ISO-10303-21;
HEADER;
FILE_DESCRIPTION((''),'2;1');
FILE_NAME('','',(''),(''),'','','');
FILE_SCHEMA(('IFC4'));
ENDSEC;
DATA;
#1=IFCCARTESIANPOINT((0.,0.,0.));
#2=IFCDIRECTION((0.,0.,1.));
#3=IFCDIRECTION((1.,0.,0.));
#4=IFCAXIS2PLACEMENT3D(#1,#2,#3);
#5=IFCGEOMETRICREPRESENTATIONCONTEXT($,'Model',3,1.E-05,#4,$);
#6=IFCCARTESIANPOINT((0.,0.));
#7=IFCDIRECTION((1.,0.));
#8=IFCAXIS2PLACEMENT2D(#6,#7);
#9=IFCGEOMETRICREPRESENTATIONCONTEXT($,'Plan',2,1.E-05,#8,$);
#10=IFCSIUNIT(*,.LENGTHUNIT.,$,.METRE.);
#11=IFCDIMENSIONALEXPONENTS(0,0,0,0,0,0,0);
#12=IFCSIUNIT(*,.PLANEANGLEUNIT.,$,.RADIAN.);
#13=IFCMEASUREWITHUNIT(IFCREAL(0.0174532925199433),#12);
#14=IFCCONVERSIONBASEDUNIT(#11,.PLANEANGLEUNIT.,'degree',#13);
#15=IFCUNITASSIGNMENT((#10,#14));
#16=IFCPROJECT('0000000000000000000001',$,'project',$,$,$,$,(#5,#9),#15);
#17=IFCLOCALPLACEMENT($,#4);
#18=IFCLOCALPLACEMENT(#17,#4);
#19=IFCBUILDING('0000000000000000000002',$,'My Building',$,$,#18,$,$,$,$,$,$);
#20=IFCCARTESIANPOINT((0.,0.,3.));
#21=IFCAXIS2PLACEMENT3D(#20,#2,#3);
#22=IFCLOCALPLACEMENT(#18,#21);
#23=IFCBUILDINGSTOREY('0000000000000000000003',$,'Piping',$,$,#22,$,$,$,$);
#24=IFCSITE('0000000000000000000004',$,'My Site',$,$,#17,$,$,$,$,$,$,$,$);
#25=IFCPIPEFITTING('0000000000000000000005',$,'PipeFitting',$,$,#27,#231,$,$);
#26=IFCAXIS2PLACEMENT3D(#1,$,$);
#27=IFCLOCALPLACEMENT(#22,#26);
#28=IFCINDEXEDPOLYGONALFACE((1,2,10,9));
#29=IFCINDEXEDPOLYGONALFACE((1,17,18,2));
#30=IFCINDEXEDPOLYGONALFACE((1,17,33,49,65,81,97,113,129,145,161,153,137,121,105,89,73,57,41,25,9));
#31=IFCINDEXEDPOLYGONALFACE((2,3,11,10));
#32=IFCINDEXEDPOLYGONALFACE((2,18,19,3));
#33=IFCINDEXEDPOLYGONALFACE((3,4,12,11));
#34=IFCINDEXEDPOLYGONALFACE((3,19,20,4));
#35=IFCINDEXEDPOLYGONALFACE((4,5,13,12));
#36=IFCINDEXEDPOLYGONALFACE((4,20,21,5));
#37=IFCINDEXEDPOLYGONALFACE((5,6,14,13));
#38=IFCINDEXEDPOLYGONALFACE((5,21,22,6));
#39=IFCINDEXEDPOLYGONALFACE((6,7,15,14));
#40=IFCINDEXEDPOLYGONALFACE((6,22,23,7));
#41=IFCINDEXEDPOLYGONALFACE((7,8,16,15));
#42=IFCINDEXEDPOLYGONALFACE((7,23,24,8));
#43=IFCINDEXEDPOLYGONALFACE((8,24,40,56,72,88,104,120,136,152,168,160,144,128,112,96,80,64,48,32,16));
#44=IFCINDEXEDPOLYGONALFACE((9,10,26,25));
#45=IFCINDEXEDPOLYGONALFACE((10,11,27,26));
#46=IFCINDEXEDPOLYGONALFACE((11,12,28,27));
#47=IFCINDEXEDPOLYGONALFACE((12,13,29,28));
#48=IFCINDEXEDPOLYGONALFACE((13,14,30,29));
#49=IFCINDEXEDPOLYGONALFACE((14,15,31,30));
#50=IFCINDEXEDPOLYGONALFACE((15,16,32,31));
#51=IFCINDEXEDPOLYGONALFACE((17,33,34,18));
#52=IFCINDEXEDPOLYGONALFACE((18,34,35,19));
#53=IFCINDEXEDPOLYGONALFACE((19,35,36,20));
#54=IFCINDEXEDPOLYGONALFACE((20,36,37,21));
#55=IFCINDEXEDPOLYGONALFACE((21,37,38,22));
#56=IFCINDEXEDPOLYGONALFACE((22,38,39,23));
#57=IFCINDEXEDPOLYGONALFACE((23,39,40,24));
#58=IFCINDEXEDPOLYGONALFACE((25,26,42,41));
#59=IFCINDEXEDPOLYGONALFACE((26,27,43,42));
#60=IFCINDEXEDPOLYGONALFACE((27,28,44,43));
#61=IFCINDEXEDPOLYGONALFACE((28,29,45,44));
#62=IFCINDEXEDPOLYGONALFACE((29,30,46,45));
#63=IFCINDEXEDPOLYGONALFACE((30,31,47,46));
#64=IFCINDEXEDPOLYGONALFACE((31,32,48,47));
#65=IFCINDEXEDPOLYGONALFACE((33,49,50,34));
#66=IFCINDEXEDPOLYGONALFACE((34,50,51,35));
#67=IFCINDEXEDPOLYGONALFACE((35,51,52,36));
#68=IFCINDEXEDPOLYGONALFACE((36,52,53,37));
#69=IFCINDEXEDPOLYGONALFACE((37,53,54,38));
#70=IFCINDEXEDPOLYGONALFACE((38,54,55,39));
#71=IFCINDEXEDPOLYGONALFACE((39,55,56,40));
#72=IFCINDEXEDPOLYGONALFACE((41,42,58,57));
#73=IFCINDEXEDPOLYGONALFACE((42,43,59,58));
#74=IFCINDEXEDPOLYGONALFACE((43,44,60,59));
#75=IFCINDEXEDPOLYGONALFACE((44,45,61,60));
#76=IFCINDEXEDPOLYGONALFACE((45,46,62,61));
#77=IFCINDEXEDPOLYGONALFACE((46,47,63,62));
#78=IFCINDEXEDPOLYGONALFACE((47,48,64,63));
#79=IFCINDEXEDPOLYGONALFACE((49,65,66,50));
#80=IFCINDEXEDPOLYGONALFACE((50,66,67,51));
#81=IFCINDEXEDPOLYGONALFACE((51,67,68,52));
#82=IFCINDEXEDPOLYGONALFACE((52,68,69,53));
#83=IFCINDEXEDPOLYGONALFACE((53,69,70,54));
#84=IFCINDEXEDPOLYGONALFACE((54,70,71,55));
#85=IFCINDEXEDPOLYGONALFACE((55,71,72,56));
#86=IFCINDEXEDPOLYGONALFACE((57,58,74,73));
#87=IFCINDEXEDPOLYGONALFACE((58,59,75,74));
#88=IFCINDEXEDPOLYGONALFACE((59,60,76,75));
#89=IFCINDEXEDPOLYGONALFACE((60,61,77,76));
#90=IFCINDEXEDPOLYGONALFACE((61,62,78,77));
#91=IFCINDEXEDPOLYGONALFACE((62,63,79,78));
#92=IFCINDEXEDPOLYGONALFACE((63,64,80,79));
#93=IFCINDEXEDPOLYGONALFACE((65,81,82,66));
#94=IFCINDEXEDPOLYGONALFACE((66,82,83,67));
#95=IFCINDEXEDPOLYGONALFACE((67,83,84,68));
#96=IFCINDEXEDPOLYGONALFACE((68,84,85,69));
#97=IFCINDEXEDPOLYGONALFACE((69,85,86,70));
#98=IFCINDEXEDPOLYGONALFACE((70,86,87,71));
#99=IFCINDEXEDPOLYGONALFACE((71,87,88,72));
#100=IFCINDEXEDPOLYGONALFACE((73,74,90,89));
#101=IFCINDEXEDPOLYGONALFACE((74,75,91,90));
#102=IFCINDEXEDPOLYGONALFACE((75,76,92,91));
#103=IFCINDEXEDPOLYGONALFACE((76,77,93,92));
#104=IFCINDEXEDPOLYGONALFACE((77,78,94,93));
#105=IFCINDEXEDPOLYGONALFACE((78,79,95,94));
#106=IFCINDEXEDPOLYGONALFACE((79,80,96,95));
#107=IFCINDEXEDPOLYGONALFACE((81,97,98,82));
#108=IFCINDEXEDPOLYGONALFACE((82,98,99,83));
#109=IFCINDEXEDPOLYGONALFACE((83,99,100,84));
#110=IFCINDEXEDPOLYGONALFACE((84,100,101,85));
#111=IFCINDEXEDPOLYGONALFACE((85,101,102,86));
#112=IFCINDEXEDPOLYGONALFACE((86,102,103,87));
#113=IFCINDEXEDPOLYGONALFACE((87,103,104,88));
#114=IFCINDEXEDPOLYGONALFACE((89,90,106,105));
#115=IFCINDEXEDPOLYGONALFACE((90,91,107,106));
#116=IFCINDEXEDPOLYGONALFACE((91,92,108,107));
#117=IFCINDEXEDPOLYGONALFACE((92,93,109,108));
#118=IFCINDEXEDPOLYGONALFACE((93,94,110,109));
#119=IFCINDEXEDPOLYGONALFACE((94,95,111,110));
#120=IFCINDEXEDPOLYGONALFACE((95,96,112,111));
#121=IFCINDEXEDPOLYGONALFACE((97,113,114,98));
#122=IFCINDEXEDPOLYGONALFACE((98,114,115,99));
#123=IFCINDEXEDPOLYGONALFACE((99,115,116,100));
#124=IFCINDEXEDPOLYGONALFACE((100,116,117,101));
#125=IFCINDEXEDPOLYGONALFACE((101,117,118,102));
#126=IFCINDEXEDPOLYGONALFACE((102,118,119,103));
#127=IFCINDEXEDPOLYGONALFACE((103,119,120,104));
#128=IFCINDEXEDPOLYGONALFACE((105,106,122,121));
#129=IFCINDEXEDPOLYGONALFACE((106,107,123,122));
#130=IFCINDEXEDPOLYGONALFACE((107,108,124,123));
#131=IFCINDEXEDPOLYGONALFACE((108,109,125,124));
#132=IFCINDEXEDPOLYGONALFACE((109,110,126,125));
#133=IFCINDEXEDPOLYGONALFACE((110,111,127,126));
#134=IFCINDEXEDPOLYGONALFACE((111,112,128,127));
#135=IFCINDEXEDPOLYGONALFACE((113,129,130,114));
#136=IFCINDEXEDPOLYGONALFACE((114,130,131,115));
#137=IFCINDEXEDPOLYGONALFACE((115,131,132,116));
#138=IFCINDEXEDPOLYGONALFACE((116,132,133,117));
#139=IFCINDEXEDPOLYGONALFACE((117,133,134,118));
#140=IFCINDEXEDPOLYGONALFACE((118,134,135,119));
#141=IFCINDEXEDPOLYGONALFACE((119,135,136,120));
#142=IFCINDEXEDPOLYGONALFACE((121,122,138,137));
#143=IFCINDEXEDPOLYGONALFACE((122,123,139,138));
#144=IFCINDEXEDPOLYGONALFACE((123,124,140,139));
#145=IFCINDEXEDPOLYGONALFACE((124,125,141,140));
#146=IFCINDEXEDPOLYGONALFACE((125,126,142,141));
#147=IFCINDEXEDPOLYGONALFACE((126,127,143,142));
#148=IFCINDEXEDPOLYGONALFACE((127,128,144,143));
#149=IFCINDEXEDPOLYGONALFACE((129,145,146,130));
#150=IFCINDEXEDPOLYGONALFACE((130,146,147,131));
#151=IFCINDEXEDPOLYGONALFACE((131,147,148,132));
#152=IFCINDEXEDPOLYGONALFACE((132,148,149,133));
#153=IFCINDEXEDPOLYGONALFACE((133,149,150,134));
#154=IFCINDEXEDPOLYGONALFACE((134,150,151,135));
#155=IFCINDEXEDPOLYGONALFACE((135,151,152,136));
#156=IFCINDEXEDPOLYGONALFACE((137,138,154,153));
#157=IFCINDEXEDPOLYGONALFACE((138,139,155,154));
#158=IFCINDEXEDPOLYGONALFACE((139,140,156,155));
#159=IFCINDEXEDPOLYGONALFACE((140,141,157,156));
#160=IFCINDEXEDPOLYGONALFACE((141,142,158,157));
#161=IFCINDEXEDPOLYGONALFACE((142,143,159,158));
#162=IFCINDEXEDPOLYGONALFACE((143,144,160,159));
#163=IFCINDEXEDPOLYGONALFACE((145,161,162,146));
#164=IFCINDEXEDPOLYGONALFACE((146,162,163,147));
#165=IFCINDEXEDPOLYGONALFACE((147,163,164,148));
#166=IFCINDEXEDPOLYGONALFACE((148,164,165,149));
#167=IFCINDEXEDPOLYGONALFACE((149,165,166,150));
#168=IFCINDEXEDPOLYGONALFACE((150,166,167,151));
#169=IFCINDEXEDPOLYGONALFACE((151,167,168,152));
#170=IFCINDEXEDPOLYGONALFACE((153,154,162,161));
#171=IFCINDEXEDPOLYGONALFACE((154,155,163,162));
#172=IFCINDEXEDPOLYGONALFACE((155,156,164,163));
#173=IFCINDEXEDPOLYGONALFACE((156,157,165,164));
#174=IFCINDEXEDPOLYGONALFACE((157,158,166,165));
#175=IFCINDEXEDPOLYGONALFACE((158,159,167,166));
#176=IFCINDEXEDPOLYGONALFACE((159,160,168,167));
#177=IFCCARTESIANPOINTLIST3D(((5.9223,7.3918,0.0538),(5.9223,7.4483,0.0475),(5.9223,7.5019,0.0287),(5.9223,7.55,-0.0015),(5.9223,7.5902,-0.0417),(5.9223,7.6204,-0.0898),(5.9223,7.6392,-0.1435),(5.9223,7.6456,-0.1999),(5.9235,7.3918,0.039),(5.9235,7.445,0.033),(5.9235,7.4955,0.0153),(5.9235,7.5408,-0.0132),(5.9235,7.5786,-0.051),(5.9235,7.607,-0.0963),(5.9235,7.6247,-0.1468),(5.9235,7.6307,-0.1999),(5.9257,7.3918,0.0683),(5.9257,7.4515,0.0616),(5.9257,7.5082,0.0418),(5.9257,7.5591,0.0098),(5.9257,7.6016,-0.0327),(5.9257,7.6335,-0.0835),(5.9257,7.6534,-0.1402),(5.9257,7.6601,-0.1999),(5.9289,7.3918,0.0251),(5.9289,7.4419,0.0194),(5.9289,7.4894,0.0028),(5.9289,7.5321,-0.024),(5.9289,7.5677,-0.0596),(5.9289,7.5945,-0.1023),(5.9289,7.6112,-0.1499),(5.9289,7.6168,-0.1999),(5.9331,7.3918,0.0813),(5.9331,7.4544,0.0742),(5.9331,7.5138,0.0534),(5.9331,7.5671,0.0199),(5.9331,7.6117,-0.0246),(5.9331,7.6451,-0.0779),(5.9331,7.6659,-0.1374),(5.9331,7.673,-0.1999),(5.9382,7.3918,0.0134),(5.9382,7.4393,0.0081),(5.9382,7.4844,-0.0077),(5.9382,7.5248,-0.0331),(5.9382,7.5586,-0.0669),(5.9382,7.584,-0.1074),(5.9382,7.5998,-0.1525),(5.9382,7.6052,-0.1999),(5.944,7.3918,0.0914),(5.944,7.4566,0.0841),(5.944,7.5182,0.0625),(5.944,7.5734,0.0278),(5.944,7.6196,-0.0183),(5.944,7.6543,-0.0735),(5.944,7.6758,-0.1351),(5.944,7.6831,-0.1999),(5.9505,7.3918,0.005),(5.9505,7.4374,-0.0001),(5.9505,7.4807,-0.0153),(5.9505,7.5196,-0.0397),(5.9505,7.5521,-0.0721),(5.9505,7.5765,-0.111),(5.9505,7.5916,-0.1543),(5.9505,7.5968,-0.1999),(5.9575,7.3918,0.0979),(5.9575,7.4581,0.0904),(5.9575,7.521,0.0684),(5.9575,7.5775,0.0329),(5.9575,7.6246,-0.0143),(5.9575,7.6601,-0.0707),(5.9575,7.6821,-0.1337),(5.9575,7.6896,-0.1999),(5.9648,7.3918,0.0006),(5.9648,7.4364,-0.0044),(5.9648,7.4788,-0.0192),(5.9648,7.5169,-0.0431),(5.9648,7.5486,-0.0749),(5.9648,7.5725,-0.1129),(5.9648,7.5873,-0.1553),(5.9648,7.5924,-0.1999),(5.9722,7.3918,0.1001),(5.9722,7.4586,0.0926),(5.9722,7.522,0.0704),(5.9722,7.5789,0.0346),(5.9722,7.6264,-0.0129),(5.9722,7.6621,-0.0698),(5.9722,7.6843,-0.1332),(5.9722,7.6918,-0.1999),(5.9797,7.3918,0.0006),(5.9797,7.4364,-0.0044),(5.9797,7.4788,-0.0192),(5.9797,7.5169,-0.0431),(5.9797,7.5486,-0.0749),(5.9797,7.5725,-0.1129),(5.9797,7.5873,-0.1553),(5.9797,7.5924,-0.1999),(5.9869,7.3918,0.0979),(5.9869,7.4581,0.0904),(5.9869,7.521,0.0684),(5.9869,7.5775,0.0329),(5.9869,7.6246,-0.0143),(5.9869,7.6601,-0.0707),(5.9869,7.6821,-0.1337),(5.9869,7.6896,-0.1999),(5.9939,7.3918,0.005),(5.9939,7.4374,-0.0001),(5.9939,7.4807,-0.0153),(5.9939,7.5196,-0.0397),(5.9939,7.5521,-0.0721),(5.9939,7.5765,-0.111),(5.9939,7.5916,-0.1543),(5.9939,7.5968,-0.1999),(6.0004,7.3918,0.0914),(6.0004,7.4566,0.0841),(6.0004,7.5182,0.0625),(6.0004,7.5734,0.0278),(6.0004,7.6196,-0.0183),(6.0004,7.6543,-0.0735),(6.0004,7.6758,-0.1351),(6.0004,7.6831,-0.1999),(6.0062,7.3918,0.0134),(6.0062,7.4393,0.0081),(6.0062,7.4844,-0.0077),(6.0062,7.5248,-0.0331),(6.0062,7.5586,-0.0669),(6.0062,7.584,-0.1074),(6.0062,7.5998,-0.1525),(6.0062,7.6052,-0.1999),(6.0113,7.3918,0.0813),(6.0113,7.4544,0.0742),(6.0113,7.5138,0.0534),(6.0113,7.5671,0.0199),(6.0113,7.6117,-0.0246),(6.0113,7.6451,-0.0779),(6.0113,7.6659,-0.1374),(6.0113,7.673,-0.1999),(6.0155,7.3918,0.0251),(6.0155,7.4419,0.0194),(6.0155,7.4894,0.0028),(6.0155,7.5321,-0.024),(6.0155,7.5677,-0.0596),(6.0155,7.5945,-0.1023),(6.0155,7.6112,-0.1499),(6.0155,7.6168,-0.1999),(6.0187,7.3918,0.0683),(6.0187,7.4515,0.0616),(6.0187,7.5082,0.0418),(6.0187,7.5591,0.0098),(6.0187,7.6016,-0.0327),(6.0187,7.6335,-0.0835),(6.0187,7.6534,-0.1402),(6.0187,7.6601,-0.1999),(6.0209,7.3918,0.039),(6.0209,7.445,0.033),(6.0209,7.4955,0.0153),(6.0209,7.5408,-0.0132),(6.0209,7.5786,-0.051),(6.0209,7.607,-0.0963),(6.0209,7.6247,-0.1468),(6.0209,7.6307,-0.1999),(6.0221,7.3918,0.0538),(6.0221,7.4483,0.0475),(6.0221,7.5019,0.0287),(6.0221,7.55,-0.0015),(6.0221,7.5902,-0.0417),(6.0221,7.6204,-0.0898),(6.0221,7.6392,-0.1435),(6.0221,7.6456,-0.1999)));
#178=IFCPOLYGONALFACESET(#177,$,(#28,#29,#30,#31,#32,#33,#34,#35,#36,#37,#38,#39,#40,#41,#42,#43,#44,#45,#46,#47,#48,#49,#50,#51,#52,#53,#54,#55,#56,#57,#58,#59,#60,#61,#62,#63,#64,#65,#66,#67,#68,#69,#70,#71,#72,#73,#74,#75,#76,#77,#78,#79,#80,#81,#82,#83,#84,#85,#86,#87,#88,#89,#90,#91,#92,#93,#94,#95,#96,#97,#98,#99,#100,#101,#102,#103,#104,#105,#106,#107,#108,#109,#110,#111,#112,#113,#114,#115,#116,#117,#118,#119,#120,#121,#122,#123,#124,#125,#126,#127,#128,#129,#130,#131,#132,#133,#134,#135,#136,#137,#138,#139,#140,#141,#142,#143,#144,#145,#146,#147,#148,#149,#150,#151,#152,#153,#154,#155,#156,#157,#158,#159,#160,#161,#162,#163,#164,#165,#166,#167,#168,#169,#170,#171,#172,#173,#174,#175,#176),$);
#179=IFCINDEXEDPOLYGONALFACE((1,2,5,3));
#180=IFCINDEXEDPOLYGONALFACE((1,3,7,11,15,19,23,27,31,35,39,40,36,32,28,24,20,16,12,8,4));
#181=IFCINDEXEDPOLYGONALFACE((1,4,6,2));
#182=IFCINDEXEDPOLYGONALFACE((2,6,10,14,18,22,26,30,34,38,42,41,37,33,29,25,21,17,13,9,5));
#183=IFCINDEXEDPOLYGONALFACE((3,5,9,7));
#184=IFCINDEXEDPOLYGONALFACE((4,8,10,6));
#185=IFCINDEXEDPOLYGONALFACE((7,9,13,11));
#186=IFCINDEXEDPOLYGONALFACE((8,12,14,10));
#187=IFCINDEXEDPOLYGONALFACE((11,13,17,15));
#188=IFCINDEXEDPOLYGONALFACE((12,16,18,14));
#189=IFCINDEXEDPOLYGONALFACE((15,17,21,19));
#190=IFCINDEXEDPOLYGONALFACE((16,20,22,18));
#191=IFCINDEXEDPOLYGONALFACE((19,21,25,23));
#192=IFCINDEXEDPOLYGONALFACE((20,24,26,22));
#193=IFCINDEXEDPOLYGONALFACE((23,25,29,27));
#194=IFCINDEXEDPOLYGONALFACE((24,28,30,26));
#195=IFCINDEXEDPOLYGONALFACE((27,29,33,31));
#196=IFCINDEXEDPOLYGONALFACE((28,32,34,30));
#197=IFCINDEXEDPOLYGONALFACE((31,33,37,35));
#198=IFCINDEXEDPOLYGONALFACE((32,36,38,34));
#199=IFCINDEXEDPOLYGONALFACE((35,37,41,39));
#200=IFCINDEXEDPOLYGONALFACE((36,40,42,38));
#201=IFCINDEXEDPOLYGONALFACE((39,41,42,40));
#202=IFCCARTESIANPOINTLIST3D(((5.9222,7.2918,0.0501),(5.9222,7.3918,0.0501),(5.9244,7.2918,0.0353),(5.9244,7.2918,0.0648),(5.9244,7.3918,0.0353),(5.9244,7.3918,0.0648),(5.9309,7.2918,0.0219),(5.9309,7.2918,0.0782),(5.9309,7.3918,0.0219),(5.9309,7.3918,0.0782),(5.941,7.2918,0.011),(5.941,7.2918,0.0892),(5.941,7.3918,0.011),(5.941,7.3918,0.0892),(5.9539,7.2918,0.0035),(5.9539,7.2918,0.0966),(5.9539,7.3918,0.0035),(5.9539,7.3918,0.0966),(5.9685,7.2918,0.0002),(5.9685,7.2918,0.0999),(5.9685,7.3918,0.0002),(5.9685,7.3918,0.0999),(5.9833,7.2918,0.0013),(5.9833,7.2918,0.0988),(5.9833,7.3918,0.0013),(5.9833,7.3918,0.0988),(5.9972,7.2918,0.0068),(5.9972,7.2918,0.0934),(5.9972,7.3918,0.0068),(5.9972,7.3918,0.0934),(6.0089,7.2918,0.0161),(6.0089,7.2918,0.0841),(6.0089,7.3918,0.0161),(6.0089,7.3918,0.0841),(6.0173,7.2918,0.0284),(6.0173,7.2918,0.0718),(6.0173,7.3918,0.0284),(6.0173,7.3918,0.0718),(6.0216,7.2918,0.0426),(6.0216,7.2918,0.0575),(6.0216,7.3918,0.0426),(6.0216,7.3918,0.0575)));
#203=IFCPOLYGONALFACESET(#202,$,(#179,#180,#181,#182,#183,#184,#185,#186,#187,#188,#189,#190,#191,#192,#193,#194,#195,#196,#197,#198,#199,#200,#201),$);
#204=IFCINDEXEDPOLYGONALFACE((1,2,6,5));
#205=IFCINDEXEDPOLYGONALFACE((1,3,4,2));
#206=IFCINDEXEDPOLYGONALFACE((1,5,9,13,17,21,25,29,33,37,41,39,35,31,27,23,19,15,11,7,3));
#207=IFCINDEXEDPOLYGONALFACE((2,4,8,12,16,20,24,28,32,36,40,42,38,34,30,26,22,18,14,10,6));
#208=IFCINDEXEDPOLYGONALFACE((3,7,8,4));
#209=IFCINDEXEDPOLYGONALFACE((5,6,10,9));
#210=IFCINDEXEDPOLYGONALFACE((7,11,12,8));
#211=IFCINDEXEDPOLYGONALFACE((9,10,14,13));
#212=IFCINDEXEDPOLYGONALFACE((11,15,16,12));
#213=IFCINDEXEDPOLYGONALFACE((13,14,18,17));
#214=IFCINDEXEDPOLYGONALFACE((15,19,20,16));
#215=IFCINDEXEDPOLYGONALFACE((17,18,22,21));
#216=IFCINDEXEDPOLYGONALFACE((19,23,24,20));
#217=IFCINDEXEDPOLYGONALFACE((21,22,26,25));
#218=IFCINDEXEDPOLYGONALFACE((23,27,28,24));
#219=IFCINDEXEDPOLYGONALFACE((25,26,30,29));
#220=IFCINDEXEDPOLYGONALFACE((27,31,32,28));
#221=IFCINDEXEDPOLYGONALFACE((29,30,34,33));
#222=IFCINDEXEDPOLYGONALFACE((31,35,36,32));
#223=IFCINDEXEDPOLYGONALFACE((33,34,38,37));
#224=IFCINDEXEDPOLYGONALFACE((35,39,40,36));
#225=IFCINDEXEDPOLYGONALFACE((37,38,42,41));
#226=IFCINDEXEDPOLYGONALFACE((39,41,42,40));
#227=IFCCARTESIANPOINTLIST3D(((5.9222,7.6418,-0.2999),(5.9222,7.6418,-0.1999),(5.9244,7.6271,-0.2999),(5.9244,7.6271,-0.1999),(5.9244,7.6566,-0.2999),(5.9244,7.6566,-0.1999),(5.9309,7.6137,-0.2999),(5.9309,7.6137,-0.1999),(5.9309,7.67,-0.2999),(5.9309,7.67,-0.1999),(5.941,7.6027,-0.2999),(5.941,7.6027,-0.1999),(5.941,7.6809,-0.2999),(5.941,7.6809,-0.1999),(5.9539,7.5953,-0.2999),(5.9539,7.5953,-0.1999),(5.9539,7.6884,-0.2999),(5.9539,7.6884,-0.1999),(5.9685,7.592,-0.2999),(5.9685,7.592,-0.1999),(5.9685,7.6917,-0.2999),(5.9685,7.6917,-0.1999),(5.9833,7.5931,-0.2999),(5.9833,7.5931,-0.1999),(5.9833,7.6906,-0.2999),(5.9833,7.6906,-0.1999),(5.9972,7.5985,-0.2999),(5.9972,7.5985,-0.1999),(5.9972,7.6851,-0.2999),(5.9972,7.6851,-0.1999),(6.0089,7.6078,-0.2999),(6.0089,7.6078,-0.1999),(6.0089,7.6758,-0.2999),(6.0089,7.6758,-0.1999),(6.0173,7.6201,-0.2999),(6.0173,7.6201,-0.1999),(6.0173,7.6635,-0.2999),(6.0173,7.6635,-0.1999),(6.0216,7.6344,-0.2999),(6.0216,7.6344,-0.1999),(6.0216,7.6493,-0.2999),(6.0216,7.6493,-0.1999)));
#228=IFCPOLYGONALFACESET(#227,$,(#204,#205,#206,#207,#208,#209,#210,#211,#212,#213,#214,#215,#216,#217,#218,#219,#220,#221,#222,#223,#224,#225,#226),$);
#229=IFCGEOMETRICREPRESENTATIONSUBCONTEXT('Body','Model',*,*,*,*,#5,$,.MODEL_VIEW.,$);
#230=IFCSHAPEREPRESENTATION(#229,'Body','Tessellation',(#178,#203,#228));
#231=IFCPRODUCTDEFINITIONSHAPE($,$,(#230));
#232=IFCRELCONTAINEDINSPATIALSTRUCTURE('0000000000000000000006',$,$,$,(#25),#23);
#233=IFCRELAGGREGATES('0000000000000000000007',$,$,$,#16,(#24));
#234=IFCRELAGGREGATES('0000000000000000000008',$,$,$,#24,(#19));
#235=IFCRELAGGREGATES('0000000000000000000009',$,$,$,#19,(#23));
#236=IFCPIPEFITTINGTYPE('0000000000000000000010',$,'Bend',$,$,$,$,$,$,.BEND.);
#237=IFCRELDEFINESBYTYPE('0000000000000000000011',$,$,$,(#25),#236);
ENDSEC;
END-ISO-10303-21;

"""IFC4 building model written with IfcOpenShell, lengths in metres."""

from ifc_helpers import new_model, entity, si_unit, converted_unit, frame, origin_with_axes, origin_2d_with_axis, place, context, subcontext, project, spatial, circle, extrude, source, transform, mapped, type_object, type_shapes, element, save


model = new_model("IFC4")

# Units and contexts
model_context = context("Model", 3, precision=1e-05, world=origin_with_axes())
plan_context = context("Plan", 2, precision=1e-05, world=origin_2d_with_axis())
body_context = subcontext(model_context, "Body", "Model", "MODEL_VIEW")
ifc_project = project(units=[si_unit("LENGTHUNIT", "METRE"), converted_unit("PLANEANGLEUNIT", "degree", entity("IfcReal", 0.0174532925199433), si_unit("PLANEANGLEUNIT", "RADIAN"), dimensions=[0, 0, 0, 0, 0, 0, 0])], contexts=[model_context, plan_context])

# Site, building, storey
site_placement = place(None, origin_with_axes())
site = spatial("IfcSite", under=ifc_project, at=site_placement, Name="My Site")
building_placement = place(site_placement, origin_with_axes())
building = spatial("IfcBuilding", under=site, at=building_placement, Name="My Building")
storey_placement = place(building_placement, frame((0.0, 0.0, 3.0), z_axis=(0.0, 0.0, 1.0), x_axis=(1.0, 0.0, 0.0)))
storey = spatial("IfcBuildingStorey", under=building, at=storey_placement, Name="Piping")

# Pipe fitting
pipe_fitting_type_1 = type_object("IfcPipeFittingType", Name="Bend", PredefinedType="BEND")
shared_shape = source(origin_with_axes(), body_context, "Body", "SolidModel", [
    entity("IfcSweptDiskSolid", entity("IfcIndexedPolyCurve", entity("IfcCartesianPointList3D", [[0.0, 0.0, 0.1], [0.0, -0.0732, 0.2768], [0.0, -0.25, 0.35]]), [entity("IfcArcIndex", [1, 2, 3])]), 0.05),
    extrude(circle(Radius=0.05), origin_with_axes(), (0.0, 0.0, 1.0), 0.1),
    extrude(circle(Radius=0.05), frame((0.0, -0.25, 0.35), z_axis=(0.0, -1.0, -0.000003), x_axis=(1.0, 0.0, 0.0)), (0.0, 0.0, 1.0), 0.1),
])
type_shapes(pipe_fitting_type_1, [shared_shape])
for number, where, z_axis, x_axis, name in (
    (1, (5.9722, 7.2918, 0.0501), (0.0, 1.0, 0.0), (-1.0, 0.0, 0.0), "PipeFitting"),
):
    element("IfcPipeFitting", number, at=place(storey_placement, frame(where, z_axis=z_axis, x_axis=x_axis)), inside=storey, type_object=pipe_fitting_type_1, Name=name, context=body_context, shape_type="MappedRepresentation", body=[
        mapped(shared_shape, transform((0.0, 0.0, 0.0), x_axis=(1.0, 0.0, 0.0), y_axis=(0.0, 1.0, 0.0), z_axis=(0.0, 0.0, 1.0), scale=1.0)),
    ])

save(model, "model.ifc")
